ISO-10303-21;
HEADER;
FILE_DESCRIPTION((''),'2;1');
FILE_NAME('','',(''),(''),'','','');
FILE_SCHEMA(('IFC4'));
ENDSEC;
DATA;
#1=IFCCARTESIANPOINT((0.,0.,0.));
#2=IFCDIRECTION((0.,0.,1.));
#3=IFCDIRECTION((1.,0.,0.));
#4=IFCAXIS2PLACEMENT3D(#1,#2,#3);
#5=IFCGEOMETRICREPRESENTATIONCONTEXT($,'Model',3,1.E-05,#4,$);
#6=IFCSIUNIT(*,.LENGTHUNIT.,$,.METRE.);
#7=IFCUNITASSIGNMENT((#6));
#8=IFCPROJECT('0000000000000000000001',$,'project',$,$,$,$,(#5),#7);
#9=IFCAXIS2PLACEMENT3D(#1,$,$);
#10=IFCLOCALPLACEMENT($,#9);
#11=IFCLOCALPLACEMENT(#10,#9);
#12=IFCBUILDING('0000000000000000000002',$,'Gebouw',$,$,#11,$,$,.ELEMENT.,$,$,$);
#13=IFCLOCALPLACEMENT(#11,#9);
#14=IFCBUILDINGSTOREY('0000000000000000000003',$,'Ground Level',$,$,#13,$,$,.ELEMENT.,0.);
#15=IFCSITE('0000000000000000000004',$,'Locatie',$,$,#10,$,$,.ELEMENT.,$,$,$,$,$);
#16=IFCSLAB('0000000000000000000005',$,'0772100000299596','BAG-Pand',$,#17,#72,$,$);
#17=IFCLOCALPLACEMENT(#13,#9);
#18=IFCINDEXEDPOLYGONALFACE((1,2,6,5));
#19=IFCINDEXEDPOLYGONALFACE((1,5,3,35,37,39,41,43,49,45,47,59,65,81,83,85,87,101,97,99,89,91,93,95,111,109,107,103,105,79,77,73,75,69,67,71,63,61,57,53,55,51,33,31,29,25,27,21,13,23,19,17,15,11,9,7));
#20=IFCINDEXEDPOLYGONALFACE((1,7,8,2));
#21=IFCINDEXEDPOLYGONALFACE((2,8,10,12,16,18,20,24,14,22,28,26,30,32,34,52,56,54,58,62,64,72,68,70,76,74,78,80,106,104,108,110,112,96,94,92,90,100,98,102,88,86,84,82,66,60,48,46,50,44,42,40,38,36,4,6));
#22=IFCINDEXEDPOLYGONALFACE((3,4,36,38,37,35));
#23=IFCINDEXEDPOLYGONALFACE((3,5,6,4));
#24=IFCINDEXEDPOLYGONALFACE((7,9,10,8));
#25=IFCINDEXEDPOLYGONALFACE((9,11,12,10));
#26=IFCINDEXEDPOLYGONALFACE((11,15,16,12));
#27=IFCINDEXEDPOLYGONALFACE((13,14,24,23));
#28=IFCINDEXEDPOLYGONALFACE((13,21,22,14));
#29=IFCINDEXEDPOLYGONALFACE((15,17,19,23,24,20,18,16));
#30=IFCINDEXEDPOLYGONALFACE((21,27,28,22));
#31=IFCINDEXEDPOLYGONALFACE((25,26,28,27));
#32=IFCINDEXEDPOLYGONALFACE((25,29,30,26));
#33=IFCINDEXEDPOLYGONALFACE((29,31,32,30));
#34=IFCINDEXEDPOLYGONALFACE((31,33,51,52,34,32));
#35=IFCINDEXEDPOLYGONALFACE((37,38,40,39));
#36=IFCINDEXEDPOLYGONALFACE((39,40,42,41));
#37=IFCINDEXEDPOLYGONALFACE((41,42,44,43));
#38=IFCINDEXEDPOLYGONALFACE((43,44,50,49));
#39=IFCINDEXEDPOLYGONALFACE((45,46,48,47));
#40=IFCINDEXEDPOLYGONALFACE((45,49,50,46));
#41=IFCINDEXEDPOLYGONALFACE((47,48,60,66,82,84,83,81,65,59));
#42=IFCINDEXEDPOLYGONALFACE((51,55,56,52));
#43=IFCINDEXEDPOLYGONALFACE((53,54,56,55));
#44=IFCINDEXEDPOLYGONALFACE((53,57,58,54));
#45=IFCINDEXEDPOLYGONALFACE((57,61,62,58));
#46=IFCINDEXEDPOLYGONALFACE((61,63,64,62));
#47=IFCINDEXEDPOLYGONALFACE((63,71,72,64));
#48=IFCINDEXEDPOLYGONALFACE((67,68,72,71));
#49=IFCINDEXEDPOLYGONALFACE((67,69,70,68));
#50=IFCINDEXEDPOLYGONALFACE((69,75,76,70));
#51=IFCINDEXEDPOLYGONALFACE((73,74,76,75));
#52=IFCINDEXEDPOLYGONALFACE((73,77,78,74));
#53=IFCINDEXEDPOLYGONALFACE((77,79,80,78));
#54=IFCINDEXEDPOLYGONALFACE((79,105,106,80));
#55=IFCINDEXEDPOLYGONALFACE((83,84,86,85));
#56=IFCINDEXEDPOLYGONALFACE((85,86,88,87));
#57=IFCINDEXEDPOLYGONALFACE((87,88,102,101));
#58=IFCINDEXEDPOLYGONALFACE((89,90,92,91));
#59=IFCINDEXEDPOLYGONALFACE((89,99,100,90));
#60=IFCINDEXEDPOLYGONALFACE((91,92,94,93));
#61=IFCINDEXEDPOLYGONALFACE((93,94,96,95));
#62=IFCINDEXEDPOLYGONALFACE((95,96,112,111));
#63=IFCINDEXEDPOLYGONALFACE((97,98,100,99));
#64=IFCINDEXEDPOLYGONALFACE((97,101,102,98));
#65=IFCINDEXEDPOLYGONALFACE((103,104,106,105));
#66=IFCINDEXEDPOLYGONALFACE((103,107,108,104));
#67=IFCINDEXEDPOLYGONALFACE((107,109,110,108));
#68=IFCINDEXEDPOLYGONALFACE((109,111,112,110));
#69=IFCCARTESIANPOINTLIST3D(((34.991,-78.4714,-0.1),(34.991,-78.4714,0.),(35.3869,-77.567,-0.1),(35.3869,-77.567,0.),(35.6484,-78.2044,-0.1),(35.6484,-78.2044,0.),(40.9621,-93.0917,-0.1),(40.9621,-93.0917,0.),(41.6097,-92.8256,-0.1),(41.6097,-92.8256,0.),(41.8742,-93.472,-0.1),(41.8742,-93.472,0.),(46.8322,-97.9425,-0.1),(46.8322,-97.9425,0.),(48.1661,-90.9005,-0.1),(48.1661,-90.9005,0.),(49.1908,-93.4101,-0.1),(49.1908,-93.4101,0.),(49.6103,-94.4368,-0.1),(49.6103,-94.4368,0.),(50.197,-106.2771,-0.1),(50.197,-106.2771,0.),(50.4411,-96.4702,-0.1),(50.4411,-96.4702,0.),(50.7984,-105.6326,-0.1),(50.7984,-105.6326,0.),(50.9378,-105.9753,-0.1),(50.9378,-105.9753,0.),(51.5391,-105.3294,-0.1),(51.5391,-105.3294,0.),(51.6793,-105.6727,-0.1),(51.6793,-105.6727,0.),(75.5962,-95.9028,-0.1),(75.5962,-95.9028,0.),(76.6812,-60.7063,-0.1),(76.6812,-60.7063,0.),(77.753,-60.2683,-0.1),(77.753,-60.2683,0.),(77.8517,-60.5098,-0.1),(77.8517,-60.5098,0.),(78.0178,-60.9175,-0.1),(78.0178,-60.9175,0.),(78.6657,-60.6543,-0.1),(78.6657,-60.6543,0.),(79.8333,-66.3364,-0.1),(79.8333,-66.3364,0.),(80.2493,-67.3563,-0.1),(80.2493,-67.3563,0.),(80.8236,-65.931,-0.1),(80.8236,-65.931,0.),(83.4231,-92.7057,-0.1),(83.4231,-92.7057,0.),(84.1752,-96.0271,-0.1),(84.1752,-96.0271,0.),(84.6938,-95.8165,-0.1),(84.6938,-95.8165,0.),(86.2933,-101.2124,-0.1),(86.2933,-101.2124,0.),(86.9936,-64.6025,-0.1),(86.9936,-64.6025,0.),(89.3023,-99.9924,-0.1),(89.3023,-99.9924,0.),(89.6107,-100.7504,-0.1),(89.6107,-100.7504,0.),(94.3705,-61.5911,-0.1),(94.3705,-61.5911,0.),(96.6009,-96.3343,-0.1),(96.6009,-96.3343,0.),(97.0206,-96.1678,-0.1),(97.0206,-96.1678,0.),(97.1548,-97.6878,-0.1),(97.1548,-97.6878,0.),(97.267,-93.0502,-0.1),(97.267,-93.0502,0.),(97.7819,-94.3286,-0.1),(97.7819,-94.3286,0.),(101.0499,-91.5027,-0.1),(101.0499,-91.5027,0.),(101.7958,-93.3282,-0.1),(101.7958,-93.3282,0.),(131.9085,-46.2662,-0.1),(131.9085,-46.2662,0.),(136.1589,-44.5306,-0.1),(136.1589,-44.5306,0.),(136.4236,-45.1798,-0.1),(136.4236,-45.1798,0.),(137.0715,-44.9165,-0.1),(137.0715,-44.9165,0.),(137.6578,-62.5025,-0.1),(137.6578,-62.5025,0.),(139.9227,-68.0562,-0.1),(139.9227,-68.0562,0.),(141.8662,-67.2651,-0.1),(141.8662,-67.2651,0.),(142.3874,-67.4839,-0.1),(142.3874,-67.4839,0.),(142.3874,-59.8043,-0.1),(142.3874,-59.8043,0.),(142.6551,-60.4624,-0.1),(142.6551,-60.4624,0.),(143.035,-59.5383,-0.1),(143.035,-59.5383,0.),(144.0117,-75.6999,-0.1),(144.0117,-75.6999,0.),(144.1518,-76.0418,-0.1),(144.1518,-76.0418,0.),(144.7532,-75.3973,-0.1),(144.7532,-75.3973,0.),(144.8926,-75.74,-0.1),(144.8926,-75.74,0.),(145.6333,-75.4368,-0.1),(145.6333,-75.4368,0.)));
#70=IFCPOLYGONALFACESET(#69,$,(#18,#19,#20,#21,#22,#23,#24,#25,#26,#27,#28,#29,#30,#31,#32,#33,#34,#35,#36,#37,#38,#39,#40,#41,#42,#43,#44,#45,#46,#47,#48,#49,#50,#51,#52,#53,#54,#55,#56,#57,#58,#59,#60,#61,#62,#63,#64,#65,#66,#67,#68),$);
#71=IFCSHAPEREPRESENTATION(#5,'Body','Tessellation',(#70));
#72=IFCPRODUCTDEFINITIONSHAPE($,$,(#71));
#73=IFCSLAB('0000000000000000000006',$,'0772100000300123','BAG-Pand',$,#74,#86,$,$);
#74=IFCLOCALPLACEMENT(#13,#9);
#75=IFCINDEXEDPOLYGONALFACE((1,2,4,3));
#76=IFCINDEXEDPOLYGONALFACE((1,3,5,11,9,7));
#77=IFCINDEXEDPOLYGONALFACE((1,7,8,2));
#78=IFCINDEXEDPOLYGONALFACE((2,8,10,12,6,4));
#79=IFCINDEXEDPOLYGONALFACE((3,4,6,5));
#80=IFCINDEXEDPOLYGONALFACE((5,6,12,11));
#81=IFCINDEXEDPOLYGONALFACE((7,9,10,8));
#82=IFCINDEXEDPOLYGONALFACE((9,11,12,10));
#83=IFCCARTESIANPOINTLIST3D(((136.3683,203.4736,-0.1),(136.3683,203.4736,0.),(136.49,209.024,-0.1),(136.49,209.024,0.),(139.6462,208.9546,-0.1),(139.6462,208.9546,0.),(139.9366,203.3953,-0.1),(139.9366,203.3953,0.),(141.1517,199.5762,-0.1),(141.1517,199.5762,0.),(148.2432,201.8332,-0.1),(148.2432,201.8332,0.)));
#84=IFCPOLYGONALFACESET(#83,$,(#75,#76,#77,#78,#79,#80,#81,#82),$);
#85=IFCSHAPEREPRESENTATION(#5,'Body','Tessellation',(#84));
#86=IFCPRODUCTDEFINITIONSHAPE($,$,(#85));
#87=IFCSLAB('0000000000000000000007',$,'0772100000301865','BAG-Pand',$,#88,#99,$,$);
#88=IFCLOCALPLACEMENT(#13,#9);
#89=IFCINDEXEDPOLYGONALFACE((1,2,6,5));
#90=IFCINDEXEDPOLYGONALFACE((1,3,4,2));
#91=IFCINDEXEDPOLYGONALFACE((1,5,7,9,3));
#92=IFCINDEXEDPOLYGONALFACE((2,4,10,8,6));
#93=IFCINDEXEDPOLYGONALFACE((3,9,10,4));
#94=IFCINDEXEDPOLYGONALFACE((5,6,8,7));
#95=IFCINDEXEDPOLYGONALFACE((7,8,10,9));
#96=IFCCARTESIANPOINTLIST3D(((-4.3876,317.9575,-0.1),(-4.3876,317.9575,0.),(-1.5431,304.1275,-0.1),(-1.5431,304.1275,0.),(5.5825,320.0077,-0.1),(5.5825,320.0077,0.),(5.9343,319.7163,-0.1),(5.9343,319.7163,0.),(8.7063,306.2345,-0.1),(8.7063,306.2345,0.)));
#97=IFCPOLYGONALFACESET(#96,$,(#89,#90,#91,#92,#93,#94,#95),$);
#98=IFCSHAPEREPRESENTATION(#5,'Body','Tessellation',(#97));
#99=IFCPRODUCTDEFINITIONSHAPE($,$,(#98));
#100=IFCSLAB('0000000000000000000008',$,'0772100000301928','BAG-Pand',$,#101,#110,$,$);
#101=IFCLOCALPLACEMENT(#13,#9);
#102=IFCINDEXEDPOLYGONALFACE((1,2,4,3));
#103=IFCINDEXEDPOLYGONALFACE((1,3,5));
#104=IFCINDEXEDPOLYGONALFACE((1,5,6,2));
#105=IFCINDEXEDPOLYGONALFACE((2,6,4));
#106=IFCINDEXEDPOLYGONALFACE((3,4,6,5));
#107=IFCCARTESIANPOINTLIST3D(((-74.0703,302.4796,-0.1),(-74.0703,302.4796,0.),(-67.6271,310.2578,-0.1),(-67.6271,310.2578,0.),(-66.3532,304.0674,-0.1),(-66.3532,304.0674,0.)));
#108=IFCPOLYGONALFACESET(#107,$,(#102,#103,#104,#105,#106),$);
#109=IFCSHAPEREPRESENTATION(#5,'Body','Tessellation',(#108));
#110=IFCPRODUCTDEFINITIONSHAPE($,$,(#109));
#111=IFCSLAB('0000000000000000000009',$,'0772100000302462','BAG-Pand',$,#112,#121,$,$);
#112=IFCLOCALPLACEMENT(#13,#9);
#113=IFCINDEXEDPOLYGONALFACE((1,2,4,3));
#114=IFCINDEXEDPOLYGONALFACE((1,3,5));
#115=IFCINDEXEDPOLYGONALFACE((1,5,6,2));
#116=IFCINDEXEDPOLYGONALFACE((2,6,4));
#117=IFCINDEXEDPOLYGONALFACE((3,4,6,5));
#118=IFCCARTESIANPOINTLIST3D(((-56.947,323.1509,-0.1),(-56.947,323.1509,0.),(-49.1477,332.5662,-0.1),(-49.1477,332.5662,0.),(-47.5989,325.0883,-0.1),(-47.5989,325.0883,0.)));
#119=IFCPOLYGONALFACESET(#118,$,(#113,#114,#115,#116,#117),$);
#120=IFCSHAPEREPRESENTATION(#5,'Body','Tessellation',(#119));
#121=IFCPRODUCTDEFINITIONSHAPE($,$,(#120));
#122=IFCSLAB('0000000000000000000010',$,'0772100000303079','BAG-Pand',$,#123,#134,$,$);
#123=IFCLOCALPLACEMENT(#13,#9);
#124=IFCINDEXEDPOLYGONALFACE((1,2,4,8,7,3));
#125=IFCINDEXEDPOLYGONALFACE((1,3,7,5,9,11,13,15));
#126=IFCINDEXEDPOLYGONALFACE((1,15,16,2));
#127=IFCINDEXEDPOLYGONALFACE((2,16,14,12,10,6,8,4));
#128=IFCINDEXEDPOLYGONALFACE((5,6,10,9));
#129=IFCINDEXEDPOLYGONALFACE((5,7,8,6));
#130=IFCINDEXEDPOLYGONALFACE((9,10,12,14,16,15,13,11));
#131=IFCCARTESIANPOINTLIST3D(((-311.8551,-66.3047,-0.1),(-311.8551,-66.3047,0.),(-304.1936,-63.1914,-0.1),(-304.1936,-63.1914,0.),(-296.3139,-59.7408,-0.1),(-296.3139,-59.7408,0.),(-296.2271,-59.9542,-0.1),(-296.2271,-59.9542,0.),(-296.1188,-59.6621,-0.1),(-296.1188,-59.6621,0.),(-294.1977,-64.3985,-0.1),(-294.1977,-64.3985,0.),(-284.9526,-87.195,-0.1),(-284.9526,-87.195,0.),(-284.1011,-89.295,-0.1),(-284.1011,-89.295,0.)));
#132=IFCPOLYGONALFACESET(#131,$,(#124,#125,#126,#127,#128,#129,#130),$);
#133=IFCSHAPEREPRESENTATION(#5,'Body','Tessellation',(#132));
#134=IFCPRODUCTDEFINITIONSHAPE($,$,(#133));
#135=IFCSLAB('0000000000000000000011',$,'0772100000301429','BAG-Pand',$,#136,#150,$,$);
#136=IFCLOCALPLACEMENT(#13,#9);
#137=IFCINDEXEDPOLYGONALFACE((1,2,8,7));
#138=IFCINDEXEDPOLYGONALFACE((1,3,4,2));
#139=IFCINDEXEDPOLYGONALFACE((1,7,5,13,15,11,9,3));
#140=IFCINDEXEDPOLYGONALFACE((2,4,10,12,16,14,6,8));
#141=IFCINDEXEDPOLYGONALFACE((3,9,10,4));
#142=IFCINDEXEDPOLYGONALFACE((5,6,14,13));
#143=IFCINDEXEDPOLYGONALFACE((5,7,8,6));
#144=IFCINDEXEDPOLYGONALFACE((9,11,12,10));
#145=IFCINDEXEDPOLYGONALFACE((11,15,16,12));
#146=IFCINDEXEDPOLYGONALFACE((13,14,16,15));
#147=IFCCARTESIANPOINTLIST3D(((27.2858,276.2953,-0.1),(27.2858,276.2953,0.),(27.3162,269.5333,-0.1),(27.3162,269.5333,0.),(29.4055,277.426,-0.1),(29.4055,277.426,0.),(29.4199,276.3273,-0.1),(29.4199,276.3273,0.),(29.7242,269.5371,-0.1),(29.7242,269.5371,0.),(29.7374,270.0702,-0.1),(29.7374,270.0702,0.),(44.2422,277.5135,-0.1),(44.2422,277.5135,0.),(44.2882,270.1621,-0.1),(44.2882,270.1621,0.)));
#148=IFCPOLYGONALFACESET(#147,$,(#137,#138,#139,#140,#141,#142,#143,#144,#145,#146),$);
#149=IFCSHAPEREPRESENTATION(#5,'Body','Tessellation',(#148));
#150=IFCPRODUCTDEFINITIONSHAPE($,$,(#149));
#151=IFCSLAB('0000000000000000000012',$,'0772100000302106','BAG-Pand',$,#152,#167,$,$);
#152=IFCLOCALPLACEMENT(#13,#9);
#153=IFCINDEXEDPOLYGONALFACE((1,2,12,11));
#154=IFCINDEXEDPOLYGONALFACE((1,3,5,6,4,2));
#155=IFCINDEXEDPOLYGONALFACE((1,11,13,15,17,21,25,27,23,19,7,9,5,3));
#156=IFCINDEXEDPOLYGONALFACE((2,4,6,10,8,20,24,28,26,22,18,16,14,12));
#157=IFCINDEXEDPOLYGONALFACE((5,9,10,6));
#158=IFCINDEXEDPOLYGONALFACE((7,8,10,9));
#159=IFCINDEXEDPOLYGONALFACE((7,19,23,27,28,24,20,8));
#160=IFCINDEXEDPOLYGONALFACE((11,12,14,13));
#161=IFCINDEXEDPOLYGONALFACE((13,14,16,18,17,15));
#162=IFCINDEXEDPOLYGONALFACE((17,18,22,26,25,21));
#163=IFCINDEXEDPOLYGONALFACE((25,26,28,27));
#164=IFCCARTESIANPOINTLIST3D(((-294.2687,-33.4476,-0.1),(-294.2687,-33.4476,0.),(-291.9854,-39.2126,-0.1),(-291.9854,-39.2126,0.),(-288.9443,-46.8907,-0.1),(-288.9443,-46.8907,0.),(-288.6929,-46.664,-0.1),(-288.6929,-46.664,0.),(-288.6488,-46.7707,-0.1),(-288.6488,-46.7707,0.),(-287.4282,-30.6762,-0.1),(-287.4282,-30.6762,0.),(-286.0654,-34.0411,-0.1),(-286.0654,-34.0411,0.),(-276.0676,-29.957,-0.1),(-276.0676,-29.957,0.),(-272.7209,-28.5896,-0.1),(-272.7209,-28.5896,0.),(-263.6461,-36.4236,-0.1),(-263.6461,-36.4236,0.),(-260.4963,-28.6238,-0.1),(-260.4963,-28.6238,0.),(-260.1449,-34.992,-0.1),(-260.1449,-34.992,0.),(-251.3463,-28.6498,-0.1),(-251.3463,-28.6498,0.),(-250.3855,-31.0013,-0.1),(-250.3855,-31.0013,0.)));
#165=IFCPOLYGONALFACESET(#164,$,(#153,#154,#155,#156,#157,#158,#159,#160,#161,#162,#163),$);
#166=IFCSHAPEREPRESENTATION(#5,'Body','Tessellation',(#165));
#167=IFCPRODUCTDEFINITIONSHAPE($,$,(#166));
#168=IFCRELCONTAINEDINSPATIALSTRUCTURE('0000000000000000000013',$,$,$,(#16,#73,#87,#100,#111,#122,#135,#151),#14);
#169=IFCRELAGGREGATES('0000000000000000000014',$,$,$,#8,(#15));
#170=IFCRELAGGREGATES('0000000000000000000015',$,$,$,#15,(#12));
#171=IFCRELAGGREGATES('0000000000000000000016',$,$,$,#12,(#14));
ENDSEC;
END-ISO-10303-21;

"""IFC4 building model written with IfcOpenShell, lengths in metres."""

from ifc_helpers import new_model, si_unit, frame, origin, origin_with_axes, place, context, project, spatial, polyline, outline, extrude, element, save


model = new_model("IFC4")

# Units and contexts
model_context = context("Model", 3, precision=1e-05, world=origin_with_axes())
ifc_project = project(units=[si_unit("LENGTHUNIT", "METRE")], contexts=[model_context])

# Site, building, storey
site_placement = place(None, origin())
site = spatial("IfcSite", under=ifc_project, at=site_placement, Name="Locatie", CompositionType="ELEMENT")
building_placement = place(site_placement, origin())
building = spatial("IfcBuilding", under=site, at=building_placement, Name="Gebouw", CompositionType="ELEMENT")
storey_placement = place(building_placement, origin())
storey = spatial("IfcBuildingStorey", under=building, at=storey_placement, Name="Ground Level", CompositionType="ELEMENT", Elevation=0.0)

# Slabs
slab_1_placement = place(storey_placement, origin())
element("IfcSlab", 1, at=slab_1_placement, inside=storey, Name="0772100000299596", Description="BAG-Pand", context=model_context, shape_type="SweptSolid", body=[
    extrude(outline(polyline([(46.8322, -97.9425), (50.4411, -96.4702), (49.6103, -94.4368), (49.1908, -93.4101), (48.1661, -90.9005), (41.8742, -93.472), (41.6097, -92.8256), (40.9621, -93.0917), (34.991, -78.4714), (35.6484, -78.2044), (35.3869, -77.567), (76.6812, -60.7063), (77.753, -60.2683), (77.8517, -60.5098), (78.0178, -60.9175), (78.6657, -60.6543), (80.8236, -65.931), (79.8333, -66.3364), (80.2493, -67.3563), (86.9936, -64.6025), (94.3705, -61.5911), (131.9085, -46.2662), (136.1589, -44.5306), (136.4236, -45.1798), (137.0715, -44.9165), (143.035, -59.5383), (142.3874, -59.8043), (142.6551, -60.4624), (137.6578, -62.5025), (139.9227, -68.0562), (141.8662, -67.2651), (142.3874, -67.4839), (145.6333, -75.4368), (144.8926, -75.74), (144.7532, -75.3973), (144.0117, -75.6999), (144.1518, -76.0418), (101.7958, -93.3282), (101.0499, -91.5027), (97.267, -93.0502), (97.7819, -94.3286), (97.0206, -96.1678), (96.6009, -96.3343), (97.1548, -97.6878), (89.6107, -100.7504), (89.3023, -99.9924), (86.2933, -101.2124), (84.1752, -96.0271), (84.6938, -95.8165), (83.4231, -92.7057), (75.5962, -95.9028), (51.6793, -105.6727), (51.5391, -105.3294), (50.7984, -105.6326), (50.9378, -105.9753), (50.197, -106.2771), (46.8322, -97.9425)])), frame((0.0, 0.0, -0.1), z_axis=(0.0, 0.0, 1.0), x_axis=(1.0, 0.0, 0.0)), (0.0, 0.0, 1.0), 0.1),
])
slab_2_placement = place(storey_placement, origin())
element("IfcSlab", 2, at=slab_2_placement, inside=storey, Name="0772100000300123", Description="BAG-Pand", context=model_context, shape_type="SweptSolid", body=[
    extrude(outline(polyline([(141.1517, 199.5762), (139.9366, 203.3953), (136.3683, 203.4736), (136.49, 209.024), (139.6462, 208.9546), (148.2432, 201.8332), (141.1517, 199.5762)])), frame((0.0, 0.0, -0.1), z_axis=(0.0, 0.0, 1.0), x_axis=(1.0, 0.0, 0.0)), (0.0, 0.0, 1.0), 0.1),
])
slab_3_placement = place(storey_placement, origin())
element("IfcSlab", 3, at=slab_3_placement, inside=storey, Name="0772100000301865", Description="BAG-Pand", context=model_context, shape_type="SweptSolid", body=[
    extrude(outline(polyline([(8.7063, 306.2345), (-1.5431, 304.1275), (-4.3876, 317.9575), (5.5825, 320.0077), (5.9343, 319.7163), (8.7063, 306.2345)])), frame((0.0, 0.0, -0.1), z_axis=(0.0, 0.0, 1.0), x_axis=(1.0, 0.0, 0.0)), (0.0, 0.0, 1.0), 0.1),
])
slab_4_placement = place(storey_placement, origin())
element("IfcSlab", 4, at=slab_4_placement, inside=storey, Name="0772100000301928", Description="BAG-Pand", context=model_context, shape_type="SweptSolid", body=[
    extrude(outline(polyline([(-66.3532, 304.0674), (-74.0703, 302.4796), (-67.6271, 310.2578), (-66.3532, 304.0674)])), frame((0.0, 0.0, -0.1), z_axis=(0.0, 0.0, 1.0), x_axis=(1.0, 0.0, 0.0)), (0.0, 0.0, 1.0), 0.1),
])
slab_5_placement = place(storey_placement, origin())
element("IfcSlab", 5, at=slab_5_placement, inside=storey, Name="0772100000302462", Description="BAG-Pand", context=model_context, shape_type="SweptSolid", body=[
    extrude(outline(polyline([(-47.5989, 325.0883), (-56.947, 323.1509), (-49.1477, 332.5662), (-47.5989, 325.0883)])), frame((0.0, 0.0, -0.1), z_axis=(0.0, 0.0, 1.0), x_axis=(1.0, 0.0, 0.0)), (0.0, 0.0, 1.0), 0.1),
])
slab_6_placement = place(storey_placement, origin())
element("IfcSlab", 6, at=slab_6_placement, inside=storey, Name="0772100000303079", Description="BAG-Pand", context=model_context, shape_type="SweptSolid", body=[
    extrude(outline(polyline([(-304.1936, -63.1914), (-296.2271, -59.9542), (-296.3139, -59.7408), (-296.1188, -59.6621), (-294.1977, -64.3985), (-284.9526, -87.195), (-284.1011, -89.295), (-311.8551, -66.3047), (-304.1936, -63.1914)])), frame((0.0, 0.0, -0.1), z_axis=(0.0, 0.0, 1.0), x_axis=(1.0, 0.0, 0.0)), (0.0, 0.0, 1.0), 0.1),
])
slab_7_placement = place(storey_placement, origin())
element("IfcSlab", 7, at=slab_7_placement, inside=storey, Name="0772100000301429", Description="BAG-Pand", context=model_context, shape_type="SweptSolid", body=[
    extrude(outline(polyline([(29.7374, 270.0702), (29.7242, 269.5371), (27.3162, 269.5333), (27.2858, 276.2953), (29.4199, 276.3273), (29.4055, 277.426), (44.2422, 277.5135), (44.2882, 270.1621), (29.7374, 270.0702)])), frame((0.0, 0.0, -0.1), z_axis=(0.0, 0.0, 1.0), x_axis=(1.0, 0.0, 0.0)), (0.0, 0.0, 1.0), 0.1),
])
slab_8_placement = place(storey_placement, origin())
element("IfcSlab", 8, at=slab_8_placement, inside=storey, Name="0772100000302106", Description="BAG-Pand", context=model_context, shape_type="SweptSolid", body=[
    extrude(outline(polyline([(-251.3463, -28.6498), (-250.3855, -31.0013), (-260.1449, -34.992), (-263.6461, -36.4236), (-288.6929, -46.664), (-288.6488, -46.7707), (-288.9443, -46.8907), (-291.9854, -39.2126), (-294.2687, -33.4476), (-287.4282, -30.6762), (-286.0654, -34.0411), (-276.0676, -29.957), (-272.7209, -28.5896), (-260.4963, -28.6238), (-251.3463, -28.6498)])), frame((0.0, 0.0, -0.1), z_axis=(0.0, 0.0, 1.0), x_axis=(1.0, 0.0, 0.0)), (0.0, 0.0, 1.0), 0.1),
])

save(model, "model.ifc")
